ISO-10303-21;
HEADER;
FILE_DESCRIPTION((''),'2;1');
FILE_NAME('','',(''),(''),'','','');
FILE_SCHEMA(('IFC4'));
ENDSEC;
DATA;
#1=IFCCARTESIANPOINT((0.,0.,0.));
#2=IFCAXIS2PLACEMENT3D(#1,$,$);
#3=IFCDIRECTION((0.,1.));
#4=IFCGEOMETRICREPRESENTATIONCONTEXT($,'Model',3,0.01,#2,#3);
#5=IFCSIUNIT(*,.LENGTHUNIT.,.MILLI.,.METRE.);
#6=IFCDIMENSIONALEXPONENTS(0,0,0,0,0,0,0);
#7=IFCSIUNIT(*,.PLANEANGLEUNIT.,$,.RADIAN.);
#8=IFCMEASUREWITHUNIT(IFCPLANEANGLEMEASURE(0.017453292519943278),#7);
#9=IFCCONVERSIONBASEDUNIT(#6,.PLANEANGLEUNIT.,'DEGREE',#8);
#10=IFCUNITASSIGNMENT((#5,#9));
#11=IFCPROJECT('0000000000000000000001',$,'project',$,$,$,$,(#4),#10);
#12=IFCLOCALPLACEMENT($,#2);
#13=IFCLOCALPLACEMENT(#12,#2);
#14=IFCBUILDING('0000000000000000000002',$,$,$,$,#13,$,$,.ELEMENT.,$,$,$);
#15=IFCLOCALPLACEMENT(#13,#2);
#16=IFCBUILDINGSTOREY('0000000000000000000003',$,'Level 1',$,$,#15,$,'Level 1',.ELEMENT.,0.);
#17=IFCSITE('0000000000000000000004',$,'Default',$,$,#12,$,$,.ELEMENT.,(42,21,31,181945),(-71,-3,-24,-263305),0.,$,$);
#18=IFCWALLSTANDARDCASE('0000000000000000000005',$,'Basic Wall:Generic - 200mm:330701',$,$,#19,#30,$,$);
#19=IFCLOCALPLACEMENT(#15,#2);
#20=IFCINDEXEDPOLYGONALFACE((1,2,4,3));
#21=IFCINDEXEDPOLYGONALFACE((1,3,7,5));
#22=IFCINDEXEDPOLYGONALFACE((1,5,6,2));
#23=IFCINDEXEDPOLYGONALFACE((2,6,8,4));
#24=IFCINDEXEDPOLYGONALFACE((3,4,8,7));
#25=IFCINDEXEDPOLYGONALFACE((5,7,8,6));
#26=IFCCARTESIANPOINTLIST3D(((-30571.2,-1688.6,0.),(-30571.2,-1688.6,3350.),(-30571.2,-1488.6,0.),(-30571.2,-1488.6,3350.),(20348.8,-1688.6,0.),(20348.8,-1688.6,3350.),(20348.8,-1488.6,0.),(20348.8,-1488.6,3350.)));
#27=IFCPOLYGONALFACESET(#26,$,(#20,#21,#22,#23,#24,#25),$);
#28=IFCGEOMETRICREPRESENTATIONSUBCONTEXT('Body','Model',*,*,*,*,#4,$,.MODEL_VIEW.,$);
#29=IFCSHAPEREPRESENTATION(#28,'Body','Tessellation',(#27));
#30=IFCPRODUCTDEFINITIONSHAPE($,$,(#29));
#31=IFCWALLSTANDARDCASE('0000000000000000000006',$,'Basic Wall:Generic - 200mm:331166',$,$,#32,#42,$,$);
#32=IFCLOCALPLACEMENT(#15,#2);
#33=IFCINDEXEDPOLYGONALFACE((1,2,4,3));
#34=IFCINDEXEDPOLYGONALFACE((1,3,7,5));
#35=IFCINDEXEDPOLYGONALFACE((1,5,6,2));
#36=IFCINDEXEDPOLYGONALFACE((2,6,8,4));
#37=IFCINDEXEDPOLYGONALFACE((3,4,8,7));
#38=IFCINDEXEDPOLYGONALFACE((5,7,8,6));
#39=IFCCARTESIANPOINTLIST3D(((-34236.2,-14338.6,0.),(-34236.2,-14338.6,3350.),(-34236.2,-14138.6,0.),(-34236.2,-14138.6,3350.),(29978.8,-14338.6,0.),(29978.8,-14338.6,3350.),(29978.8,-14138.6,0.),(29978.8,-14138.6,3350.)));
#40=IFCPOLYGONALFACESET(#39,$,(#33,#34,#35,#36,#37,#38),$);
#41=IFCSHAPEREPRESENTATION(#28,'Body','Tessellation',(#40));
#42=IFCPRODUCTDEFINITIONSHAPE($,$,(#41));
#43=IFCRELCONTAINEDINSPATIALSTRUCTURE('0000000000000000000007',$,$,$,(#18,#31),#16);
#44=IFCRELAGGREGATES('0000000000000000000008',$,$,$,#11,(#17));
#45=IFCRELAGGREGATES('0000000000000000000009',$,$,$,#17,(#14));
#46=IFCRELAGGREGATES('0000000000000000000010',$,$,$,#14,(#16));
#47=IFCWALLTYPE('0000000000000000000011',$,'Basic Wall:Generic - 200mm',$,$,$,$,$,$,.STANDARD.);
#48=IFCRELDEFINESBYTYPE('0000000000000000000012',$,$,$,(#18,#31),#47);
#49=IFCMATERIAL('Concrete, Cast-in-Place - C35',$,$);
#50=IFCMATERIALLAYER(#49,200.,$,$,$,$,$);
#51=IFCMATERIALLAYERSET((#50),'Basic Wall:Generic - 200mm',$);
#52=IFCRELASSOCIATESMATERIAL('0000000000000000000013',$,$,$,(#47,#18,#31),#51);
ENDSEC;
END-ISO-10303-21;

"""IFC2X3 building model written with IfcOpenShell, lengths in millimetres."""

from ifc_helpers import new_model, entity, si_unit, converted_unit, direction, frame, frame_2d, origin, place, context, subcontext, project, spatial, rectangle, extrude, material, layer, layer_set, layer_usage, type_object, element, save


model = new_model("IFC2X3")

# Units and contexts
model_context = context("Model", 3, precision=0.01, world=origin(), true_north=direction((0.0, 1.0)))
body_context = subcontext(model_context, "Body", "Model", "MODEL_VIEW")
ifc_project = project(units=[si_unit("LENGTHUNIT", "METRE", prefix="MILLI"), converted_unit("PLANEANGLEUNIT", "DEGREE", entity("IfcPlaneAngleMeasure", 0.017453292519943278), si_unit("PLANEANGLEUNIT", "RADIAN"), dimensions=[0, 0, 0, 0, 0, 0, 0])], contexts=[model_context])

# Site, building, storey
site_placement = place(None, origin())
site = spatial("IfcSite", under=ifc_project, at=site_placement, Name="Default", CompositionType="ELEMENT", RefLatitude=(42, 21, 31, 181945), RefLongitude=(-71, -3, -24, -263305), RefElevation=0.0)
building_placement = place(site_placement, origin())
building = spatial("IfcBuilding", under=site, at=building_placement, CompositionType="ELEMENT")
storey_placement = place(building_placement, origin())
storey = spatial("IfcBuildingStorey", under=building, at=storey_placement, Name="Level 1", LongName="Level 1", CompositionType="ELEMENT", Elevation=0.0)

# Shared definitions
ifc_material = material(Name="Concrete, Cast-in-Place - C35")

# Walls
ifc_layer = layer(ifc_material, 200.0)
ifc_layer_set = layer_set([ifc_layer], Name="Basic Wall:Generic - 200mm")
ifc_layer_usage_1 = layer_usage(ifc_layer_set, "AXIS2", "NEGATIVE", 100.0)
wall_type = type_object("IfcWallType", Name="Basic Wall:Generic - 200mm", PredefinedType="STANDARD", material=ifc_layer_set)
wall_1_placement = place(storey_placement, frame((-30571.2, -1588.6, 0.0)))
element("IfcWallStandardCase", 1, at=wall_1_placement, inside=storey, type_object=wall_type, material=ifc_layer_usage_1, Name="Basic Wall:Generic - 200mm:330701", context=body_context, shape_type="SweptSolid", body=[
    extrude(rectangle(XDim=50920.0, YDim=200.0, at=frame_2d((25460.0, 0.0), x_axis=(-1.0, 0.0))), origin(), (0.0, 0.0, 1.0), 3350.0),
])
ifc_layer_usage_2 = layer_usage(ifc_layer_set, "AXIS2", "NEGATIVE", 100.0)
wall_2_placement = place(storey_placement, frame((-34236.2, -14238.6, 0.0)))
element("IfcWallStandardCase", 2, at=wall_2_placement, inside=storey, type_object=wall_type, material=ifc_layer_usage_2, Name="Basic Wall:Generic - 200mm:331166", context=body_context, shape_type="SweptSolid", body=[
    extrude(rectangle(XDim=64215.0, YDim=200.0, at=frame_2d((32107.5, 0.0), x_axis=(-1.0, 0.0))), origin(), (0.0, 0.0, 1.0), 3350.0),
])

save(model, "model.ifc")
